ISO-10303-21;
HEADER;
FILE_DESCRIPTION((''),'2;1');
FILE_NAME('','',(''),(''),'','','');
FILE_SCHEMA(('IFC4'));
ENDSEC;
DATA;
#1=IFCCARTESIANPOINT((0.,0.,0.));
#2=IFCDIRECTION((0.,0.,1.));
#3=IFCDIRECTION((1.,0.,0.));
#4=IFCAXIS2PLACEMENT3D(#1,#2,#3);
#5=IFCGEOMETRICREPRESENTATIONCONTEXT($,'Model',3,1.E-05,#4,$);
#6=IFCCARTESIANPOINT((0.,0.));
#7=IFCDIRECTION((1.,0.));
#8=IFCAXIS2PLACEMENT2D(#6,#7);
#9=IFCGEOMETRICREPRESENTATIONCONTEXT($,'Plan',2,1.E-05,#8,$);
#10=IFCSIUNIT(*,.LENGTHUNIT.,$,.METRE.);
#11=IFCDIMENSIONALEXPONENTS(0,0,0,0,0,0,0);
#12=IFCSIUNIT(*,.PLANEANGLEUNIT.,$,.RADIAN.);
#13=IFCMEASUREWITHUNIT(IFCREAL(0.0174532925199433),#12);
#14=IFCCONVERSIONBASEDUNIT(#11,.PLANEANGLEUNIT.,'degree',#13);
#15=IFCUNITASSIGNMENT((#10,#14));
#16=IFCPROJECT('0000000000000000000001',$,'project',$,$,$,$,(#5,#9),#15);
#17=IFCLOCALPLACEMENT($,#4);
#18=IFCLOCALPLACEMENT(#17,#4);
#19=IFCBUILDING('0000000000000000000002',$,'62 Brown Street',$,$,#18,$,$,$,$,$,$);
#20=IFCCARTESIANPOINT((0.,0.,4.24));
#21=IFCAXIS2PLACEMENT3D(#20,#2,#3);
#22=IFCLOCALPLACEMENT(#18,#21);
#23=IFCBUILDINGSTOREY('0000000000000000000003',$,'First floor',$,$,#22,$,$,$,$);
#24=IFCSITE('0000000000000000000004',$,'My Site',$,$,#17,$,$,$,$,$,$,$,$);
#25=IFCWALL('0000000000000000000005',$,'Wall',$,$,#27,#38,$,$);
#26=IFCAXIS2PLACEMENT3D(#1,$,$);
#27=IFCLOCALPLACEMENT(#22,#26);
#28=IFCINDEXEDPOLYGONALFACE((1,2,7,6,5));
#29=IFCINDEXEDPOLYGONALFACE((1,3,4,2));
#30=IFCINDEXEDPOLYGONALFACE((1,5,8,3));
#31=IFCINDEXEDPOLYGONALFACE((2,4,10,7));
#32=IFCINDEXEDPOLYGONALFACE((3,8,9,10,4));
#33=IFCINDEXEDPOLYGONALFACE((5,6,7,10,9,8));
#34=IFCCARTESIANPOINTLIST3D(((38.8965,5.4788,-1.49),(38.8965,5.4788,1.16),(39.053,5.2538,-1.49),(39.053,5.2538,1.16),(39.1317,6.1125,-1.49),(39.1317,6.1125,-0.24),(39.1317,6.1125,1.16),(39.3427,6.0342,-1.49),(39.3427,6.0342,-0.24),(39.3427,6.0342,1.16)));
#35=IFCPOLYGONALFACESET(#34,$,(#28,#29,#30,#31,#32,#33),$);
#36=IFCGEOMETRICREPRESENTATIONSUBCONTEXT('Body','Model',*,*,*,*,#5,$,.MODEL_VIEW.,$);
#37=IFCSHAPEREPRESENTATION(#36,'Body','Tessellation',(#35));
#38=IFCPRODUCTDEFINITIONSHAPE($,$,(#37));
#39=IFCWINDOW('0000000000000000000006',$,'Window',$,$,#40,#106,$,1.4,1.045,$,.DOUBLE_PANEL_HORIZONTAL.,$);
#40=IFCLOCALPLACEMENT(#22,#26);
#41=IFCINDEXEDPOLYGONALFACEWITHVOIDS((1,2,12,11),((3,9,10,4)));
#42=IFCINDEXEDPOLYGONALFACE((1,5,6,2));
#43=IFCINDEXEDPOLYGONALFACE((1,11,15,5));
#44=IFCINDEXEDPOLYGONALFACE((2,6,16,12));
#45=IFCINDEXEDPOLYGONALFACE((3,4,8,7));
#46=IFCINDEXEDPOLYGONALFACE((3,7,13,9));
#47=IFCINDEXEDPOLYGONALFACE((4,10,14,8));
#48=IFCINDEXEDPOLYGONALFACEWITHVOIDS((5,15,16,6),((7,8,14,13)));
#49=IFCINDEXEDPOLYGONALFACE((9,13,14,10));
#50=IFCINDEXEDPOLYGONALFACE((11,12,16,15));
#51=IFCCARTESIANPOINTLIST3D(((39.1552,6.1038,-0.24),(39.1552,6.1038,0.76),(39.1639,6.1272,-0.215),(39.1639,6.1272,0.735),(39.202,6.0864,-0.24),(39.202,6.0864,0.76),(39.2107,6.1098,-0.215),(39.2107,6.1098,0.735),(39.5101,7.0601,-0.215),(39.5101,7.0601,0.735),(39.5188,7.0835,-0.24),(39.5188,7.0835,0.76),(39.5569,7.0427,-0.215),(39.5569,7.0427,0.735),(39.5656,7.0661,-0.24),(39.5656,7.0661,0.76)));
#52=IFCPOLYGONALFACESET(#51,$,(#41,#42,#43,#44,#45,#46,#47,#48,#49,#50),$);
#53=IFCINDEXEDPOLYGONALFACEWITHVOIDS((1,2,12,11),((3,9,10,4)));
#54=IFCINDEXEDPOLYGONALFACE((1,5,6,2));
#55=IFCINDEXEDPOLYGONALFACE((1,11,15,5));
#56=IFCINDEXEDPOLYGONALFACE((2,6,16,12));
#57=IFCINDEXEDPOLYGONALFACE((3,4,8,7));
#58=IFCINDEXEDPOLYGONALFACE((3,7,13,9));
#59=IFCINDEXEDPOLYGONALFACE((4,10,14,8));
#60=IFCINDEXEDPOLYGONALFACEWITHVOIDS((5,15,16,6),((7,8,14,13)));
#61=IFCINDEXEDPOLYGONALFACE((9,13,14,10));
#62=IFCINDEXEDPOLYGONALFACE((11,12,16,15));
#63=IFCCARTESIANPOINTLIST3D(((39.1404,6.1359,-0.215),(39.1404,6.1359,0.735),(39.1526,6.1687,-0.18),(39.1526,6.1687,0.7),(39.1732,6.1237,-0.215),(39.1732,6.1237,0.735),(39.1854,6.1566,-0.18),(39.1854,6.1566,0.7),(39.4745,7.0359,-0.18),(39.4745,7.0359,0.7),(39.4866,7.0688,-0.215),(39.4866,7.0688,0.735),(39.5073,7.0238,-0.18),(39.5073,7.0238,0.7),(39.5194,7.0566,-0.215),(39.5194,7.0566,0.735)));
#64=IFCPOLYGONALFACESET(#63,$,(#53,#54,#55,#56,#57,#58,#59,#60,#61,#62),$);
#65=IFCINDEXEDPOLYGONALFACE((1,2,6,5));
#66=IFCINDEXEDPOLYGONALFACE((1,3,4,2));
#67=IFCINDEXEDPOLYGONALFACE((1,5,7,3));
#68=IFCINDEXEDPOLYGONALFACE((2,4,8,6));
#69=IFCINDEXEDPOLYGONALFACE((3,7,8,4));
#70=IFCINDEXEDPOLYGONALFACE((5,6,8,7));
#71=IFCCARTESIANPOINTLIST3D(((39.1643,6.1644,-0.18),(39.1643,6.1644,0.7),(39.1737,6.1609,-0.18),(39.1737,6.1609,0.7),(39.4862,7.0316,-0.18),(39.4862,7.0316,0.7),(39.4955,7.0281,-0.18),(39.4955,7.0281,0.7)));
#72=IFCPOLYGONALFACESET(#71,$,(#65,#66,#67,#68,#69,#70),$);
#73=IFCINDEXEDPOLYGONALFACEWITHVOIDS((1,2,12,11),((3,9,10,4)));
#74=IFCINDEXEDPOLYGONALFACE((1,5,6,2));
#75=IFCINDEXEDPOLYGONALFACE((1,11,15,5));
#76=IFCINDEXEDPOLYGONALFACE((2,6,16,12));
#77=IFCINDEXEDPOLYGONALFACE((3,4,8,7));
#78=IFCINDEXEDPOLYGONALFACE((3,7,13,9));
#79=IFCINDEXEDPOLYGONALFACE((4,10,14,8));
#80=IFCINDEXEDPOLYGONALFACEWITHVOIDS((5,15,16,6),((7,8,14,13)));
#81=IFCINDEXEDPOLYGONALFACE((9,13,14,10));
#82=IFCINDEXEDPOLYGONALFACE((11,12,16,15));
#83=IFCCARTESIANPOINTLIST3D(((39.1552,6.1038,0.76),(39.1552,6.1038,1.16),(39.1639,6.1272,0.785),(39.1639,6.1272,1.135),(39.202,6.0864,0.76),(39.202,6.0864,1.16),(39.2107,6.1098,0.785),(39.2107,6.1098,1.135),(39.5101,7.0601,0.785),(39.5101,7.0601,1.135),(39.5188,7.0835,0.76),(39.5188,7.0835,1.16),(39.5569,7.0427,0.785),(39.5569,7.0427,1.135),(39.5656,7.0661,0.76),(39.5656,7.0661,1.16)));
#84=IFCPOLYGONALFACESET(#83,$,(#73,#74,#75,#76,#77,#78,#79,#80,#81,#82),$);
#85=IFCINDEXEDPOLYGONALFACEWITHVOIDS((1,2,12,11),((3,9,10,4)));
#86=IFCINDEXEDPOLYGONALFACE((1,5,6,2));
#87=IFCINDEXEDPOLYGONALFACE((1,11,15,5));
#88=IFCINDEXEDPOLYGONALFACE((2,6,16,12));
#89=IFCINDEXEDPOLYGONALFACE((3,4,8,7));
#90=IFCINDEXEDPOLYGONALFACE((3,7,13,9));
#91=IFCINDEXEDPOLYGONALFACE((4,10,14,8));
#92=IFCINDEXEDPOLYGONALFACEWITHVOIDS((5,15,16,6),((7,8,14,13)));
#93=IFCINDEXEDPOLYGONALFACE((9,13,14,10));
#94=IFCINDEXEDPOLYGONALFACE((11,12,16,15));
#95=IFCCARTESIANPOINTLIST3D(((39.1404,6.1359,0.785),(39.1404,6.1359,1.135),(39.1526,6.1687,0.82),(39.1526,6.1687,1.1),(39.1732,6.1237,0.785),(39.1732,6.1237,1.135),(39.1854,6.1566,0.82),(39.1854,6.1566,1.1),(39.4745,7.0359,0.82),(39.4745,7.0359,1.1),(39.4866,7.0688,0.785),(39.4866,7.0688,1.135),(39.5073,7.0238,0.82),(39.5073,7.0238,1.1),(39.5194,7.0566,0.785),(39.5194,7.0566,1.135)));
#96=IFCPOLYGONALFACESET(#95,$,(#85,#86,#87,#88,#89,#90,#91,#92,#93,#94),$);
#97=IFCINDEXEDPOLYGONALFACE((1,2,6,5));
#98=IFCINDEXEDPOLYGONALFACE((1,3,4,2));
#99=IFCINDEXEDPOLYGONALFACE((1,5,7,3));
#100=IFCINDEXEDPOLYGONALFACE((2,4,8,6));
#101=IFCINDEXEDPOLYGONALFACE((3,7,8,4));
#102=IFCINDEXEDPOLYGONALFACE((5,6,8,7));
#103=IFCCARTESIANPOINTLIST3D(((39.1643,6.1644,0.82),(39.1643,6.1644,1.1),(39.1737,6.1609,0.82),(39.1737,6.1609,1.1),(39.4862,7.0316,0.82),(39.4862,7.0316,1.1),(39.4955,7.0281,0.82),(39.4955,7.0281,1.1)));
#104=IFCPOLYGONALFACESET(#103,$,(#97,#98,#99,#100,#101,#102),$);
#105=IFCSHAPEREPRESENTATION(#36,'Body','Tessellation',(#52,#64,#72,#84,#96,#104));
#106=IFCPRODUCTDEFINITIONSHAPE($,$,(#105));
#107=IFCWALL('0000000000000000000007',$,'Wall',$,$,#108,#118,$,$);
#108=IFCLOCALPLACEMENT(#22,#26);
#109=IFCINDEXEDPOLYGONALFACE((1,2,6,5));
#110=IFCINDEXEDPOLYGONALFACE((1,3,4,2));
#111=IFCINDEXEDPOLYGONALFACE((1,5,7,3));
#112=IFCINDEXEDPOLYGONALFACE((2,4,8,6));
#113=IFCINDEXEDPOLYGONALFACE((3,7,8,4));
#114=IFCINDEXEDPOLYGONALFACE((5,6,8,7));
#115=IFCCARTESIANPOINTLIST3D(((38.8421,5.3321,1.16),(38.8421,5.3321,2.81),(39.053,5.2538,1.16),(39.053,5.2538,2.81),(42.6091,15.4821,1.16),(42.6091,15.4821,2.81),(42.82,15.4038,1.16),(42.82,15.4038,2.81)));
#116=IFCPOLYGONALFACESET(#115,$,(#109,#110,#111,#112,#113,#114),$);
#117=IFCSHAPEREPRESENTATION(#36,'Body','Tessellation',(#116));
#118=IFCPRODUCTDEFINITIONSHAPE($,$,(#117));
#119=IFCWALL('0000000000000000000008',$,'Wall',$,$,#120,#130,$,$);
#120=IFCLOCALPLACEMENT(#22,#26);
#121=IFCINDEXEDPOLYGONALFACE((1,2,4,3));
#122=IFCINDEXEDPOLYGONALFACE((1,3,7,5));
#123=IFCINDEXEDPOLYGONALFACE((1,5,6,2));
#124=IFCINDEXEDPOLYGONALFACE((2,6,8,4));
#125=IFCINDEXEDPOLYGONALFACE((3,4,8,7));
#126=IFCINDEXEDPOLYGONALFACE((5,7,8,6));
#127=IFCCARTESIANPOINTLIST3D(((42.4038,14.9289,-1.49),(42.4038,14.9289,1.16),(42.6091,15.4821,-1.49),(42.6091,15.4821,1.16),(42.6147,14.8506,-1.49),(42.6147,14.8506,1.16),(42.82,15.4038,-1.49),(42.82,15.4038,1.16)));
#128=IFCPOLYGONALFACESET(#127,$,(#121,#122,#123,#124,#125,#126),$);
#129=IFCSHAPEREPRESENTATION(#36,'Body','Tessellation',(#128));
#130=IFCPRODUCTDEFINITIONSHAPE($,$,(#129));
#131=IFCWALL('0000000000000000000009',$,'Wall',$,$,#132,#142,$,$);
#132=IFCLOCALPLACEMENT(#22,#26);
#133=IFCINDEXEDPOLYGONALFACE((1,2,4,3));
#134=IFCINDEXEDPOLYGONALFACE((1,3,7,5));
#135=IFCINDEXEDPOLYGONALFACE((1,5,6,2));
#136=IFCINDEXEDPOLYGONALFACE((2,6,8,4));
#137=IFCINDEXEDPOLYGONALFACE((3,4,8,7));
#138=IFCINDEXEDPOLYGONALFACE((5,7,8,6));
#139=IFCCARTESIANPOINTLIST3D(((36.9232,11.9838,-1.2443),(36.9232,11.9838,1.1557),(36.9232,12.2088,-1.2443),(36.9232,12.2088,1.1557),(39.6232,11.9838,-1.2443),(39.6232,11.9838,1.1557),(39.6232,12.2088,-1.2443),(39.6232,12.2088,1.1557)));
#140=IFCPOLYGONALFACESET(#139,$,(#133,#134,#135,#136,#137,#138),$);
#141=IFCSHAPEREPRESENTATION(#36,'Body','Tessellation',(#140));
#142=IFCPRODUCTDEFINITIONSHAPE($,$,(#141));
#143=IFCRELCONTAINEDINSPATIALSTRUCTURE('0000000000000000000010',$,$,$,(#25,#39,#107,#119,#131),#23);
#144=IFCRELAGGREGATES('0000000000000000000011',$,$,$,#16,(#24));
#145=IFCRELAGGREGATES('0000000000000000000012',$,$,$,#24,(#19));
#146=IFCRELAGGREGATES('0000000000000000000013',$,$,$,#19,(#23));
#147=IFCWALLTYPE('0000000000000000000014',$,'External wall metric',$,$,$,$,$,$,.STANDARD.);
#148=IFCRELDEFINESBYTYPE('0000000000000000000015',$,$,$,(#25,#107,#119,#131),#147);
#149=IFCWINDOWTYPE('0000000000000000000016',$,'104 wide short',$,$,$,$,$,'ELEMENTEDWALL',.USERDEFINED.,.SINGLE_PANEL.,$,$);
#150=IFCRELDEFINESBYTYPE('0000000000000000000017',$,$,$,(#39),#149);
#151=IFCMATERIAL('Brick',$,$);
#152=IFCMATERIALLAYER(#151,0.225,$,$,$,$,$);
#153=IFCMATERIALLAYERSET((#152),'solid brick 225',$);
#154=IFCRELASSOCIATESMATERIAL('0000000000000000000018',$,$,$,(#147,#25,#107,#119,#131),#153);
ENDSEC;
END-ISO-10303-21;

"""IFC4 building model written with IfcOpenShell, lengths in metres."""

from ifc_helpers import new_model, entity, si_unit, converted_unit, frame, origin_with_axes, origin_2d_with_axis, place, context, subcontext, project, spatial, line, indexed_curve, outline, extrude, clip, halfspace, shape, source, transform, mapped, material, layer, layer_set, layer_usage, type_object, type_shapes, element, fill, save


model = new_model("IFC4")

# Units and contexts
model_context = context("Model", 3, precision=1e-05, world=origin_with_axes())
plan_context = context("Plan", 2, precision=1e-05, world=origin_2d_with_axis())
body_context_1 = subcontext(model_context, "Body", "Model", "MODEL_VIEW")
body_context_2 = subcontext(plan_context, "Body", "Plan", "PLAN_VIEW")
ifc_project = project(units=[si_unit("LENGTHUNIT", "METRE"), converted_unit("PLANEANGLEUNIT", "degree", entity("IfcReal", 0.0174532925199433), si_unit("PLANEANGLEUNIT", "RADIAN"), dimensions=[0, 0, 0, 0, 0, 0, 0])], contexts=[model_context, plan_context])

# Site, building, storey
site_placement = place(None, origin_with_axes())
site = spatial("IfcSite", under=ifc_project, at=site_placement, Name="My Site")
building_placement = place(site_placement, origin_with_axes())
building = spatial("IfcBuilding", under=site, at=building_placement, Name="62 Brown Street")
storey_placement = place(building_placement, frame((0.0, 0.0, 4.24), z_axis=(0.0, 0.0, 1.0), x_axis=(1.0, 0.0, 0.0)))
storey = spatial("IfcBuildingStorey", under=building, at=storey_placement, Name="First floor")

# Shared definitions
ifc_material_1 = material(Name="Brick")
ifc_layer_1 = layer(ifc_material_1, 0.225)
ifc_layer_set_1 = layer_set([ifc_layer_1], Name="solid brick 225")
wall_type_1 = type_object("IfcWallType", Name="External wall metric", PredefinedType="STANDARD", material=ifc_layer_set_1)

# Wall, opening, window
ifc_layer_usage_1 = layer_usage(ifc_layer_set_1, "AXIS2", "POSITIVE", 0.0)
wall_1_placement = place(storey_placement, frame((39.024, 5.1755, -1.49), z_axis=(0.0, 0.0, 1.0), x_axis=(0.347944, 0.937515, 0.0)))
wall_1 = element("IfcWall", 1, at=wall_1_placement, inside=storey, type_object=wall_type_1, material=ifc_layer_usage_1, Name="Wall", context=body_context_1, shape_type="Clipping", body=[
    clip(extrude(outline(indexed_curve([(0.0, 0.0), (0.0, 0.225), (0.9159, 0.225), (0.9159, 0.0), (0.0, 0.0)], self_intersect=False)), origin_with_axes(), (0.0, 0.0, 1.0), 2.65), halfspace(frame((0.0835, 0.0, -2.75), z_axis=(-0.596249, 0.414702, 0.0), x_axis=(0.156491, 0.225, 0.0)), False)),
])
shared_shape_1 = source(origin_with_axes(), body_context_1, "Body", "SweptSolid", [
    extrude(outline(indexed_curve([(0.0, 0.0), (1.045, 0.0), (1.045, 1.4), (0.0, 1.4)], segments=[line(1, 2, 3, 4, 1)])), frame((0.0, -0.1, 0.0), z_axis=(0.0, -1.0, 0.0), x_axis=(1.0, 0.0, 0.0)), (0.0, 0.0, -1.0), 0.425),
])
opening_placement = place(wall_1_placement, frame((0.9159, 0.0, 1.25), z_axis=(0.0, 0.0, 1.0), x_axis=(1.0, 0.0, 0.0)))
opening = element("IfcOpeningElement", 2, at=opening_placement, cuts=wall_1, PredefinedType="OPENING", context=body_context_1, shape_type="MappedRepresentation", body=[
    mapped(shared_shape_1, transform((0.0, 0.0, 0.0), x_axis=(1.0, 0.0, 0.0), y_axis=(0.0, 1.0, 0.0), z_axis=(0.0, 0.0, 1.0), scale=1.0)),
])
window_type = type_object("IfcWindowType", Name="104 wide short", ElementType="ELEMENTEDWALL", PartitioningType="SINGLE_PANEL", PredefinedType="USERDEFINED")
shared_shape_2 = source(origin_with_axes(), body_context_1, "Body", "SweptSolid", [
    extrude(outline(indexed_curve([(0.0, 0.0), (1.045, 0.0), (1.045, 1.0), (0.0, 1.0)], segments=[line(1, 2, 3, 4, 1)]), holes=[indexed_curve([(0.025, 0.025), (1.02, 0.025), (1.02, 0.975), (0.025, 0.975)], segments=[line(1, 2, 3, 4, 1)])]), frame((0.0, 0.15, 0.0), z_axis=(0.0, -1.0, 0.0), x_axis=(1.0, 0.0, 0.0)), (0.0, 0.0, -1.0), 0.05),
    extrude(outline(indexed_curve([(0.0, 0.0), (0.995, 0.0), (0.995, 0.95), (0.0, 0.95)], segments=[line(1, 2, 3, 4, 1)]), holes=[indexed_curve([(0.035, 0.035), (0.96, 0.035), (0.96, 0.915), (0.035, 0.915)], segments=[line(1, 2, 3, 4, 1)])]), frame((0.025, 0.19, 0.025), z_axis=(0.0, -1.0, 0.0), x_axis=(1.0, 0.0, 0.0)), (0.0, 0.0, -1.0), 0.035),
    extrude(outline(indexed_curve([(0.035, 0.035), (0.96, 0.035), (0.96, 0.915), (0.035, 0.915)], segments=[line(1, 2, 3, 4, 1)])), frame((0.025, 0.2025, 0.025), z_axis=(0.0, -1.0, 0.0), x_axis=(1.0, 0.0, 0.0)), (0.0, 0.0, -1.0), 0.01),
    extrude(outline(indexed_curve([(0.0, 0.0), (1.045, 0.0), (1.045, 0.4), (0.0, 0.4)], segments=[line(1, 2, 3, 4, 1)]), holes=[indexed_curve([(0.025, 0.025), (1.02, 0.025), (1.02, 0.375), (0.025, 0.375)], segments=[line(1, 2, 3, 4, 1)])]), frame((0.0, 0.15, 1.0), z_axis=(0.0, -1.0, 0.0), x_axis=(1.0, 0.0, 0.0)), (0.0, 0.0, -1.0), 0.05),
    extrude(outline(indexed_curve([(0.0, 0.0), (0.995, 0.0), (0.995, 0.35), (0.0, 0.35)], segments=[line(1, 2, 3, 4, 1)]), holes=[indexed_curve([(0.035, 0.035), (0.96, 0.035), (0.96, 0.315), (0.035, 0.315)], segments=[line(1, 2, 3, 4, 1)])]), frame((0.025, 0.19, 1.025), z_axis=(0.0, -1.0, 0.0), x_axis=(1.0, 0.0, 0.0)), (0.0, 0.0, -1.0), 0.035),
    extrude(outline(indexed_curve([(0.035, 0.035), (0.96, 0.035), (0.96, 0.315), (0.035, 0.315)], segments=[line(1, 2, 3, 4, 1)])), frame((0.025, 0.2025, 1.025), z_axis=(0.0, -1.0, 0.0), x_axis=(1.0, 0.0, 0.0)), (0.0, 0.0, -1.0), 0.01),
])
shared_shape_3 = source(origin_with_axes(), body_context_2, "Body", "Curve2D", [
    entity("IfcIndexedPolyCurve", entity("IfcCartesianPointList2D", [[0.025, 0.15], [1.02, 0.15]])),
    entity("IfcIndexedPolyCurve", entity("IfcCartesianPointList2D", [[0.0, 0.2], [0.025, 0.2], [0.025, 0.15], [0.0, 0.15]]), [entity("IfcLineIndex", [1, 2, 3, 4, 1])]),
    entity("IfcIndexedPolyCurve", entity("IfcCartesianPointList2D", [[1.045, 0.2], [1.02, 0.2], [1.02, 0.15], [1.045, 0.15]]), [entity("IfcLineIndex", [1, 2, 3, 4, 1])]),
    entity("IfcIndexedPolyCurve", entity("IfcCartesianPointList2D", [[0.025, 0.19], [0.06, 0.19], [0.06, 0.225], [0.025, 0.225]]), [entity("IfcLineIndex", [1, 2, 3, 4, 1])]),
    entity("IfcIndexedPolyCurve", entity("IfcCartesianPointList2D", [[1.02, 0.19], [0.985, 0.19], [0.985, 0.225], [1.02, 0.225]]), [entity("IfcLineIndex", [1, 2, 3, 4, 1])]),
    entity("IfcIndexedPolyCurve", entity("IfcCartesianPointList2D", [[0.06, 0.19], [0.985, 0.19]])),
    entity("IfcIndexedPolyCurve", entity("IfcCartesianPointList2D", [[0.06, 0.225], [0.985, 0.225]])),
    entity("IfcIndexedPolyCurve", entity("IfcCartesianPointList2D", [[0.06, 0.2075], [0.985, 0.2075]])),
])
type_shapes(window_type, [shared_shape_2, shared_shape_3])
window_1_placement = place(opening_placement, frame((0.0, 0.0, 0.0), z_axis=(0.0, 0.0, 1.0), x_axis=(1.0, 0.0, 0.0)))
window_1 = element("IfcWindow", 3, at=window_1_placement, inside=storey, type_object=window_type, Name="Window", OverallHeight=1.4, OverallWidth=1.045, PartitioningType="DOUBLE_PANEL_HORIZONTAL", shapes=[
    shape(body_context_1, "Body", "MappedRepresentation", [mapped(shared_shape_2, transform((0.0, 0.0, 0.0), x_axis=(1.0, 0.0, 0.0), y_axis=(0.0, 1.0, 0.0), z_axis=(0.0, 0.0, 1.0), scale=1.0))]),
    shape(body_context_2, "Body", "MappedRepresentation", [mapped(shared_shape_3, transform((0.0, 0.0, 0.0), x_axis=(1.0, 0.0, 0.0), y_axis=(0.0, 1.0, 0.0), z_axis=(0.0, 0.0, 1.0), scale=1.0))]),
])
fill(opening, window_1)

# Walls
ifc_layer_usage_2 = layer_usage(ifc_layer_set_1, "AXIS2", "POSITIVE", 0.0)
wall_2_placement = place(storey_placement, frame((39.053, 5.2538, 1.16), z_axis=(0.0, 0.0, 1.0), x_axis=(0.347944, 0.937515, 0.0)))
element("IfcWall", 4, at=wall_2_placement, inside=storey, type_object=wall_type_1, material=ifc_layer_usage_2, Name="Wall", context=body_context_1, shape_type="SweptSolid", body=[
    extrude(outline(indexed_curve([(0.0, 0.0), (0.0, 0.225), (10.8265, 0.225), (10.8265, 0.0), (0.0, 0.0)], self_intersect=False)), origin_with_axes(), (0.0, 0.0, 1.0), 1.65),
])
ifc_layer_usage_3 = layer_usage(ifc_layer_set_1, "AXIS2", "POSITIVE", 0.0)
wall_3_placement = place(storey_placement, frame((42.6147, 14.8506, -1.49), z_axis=(0.0, 0.0, 1.0), x_axis=(0.347944, 0.937515, 0.0)))
element("IfcWall", 5, at=wall_3_placement, inside=storey, type_object=wall_type_1, material=ifc_layer_usage_3, Name="Wall", context=body_context_1, shape_type="SweptSolid", body=[
    extrude(outline(indexed_curve([(0.0, 0.0), (0.0, 0.225), (0.5901, 0.225), (0.5901, 0.0), (0.0, 0.0)], self_intersect=False)), origin_with_axes(), (0.0, 0.0, 1.0), 2.65),
])
ifc_layer_usage_4 = layer_usage(ifc_layer_set_1, "AXIS2", "POSITIVE", 0.0)
wall_4_placement = place(storey_placement, frame((36.9232, 11.9838, -1.2443), z_axis=(0.0, 0.0, 1.0), x_axis=(1.0, 0.0, 0.0)))
element("IfcWall", 6, at=wall_4_placement, inside=storey, type_object=wall_type_1, material=ifc_layer_usage_4, Name="Wall", context=body_context_1, shape_type="SweptSolid", body=[
    extrude(outline(indexed_curve([(0.0, 0.0), (0.0, 0.225), (2.7, 0.225), (2.7, 0.0), (0.0, 0.0)], self_intersect=False)), origin_with_axes(), (0.0, 0.0, 1.0), 2.4),
])

save(model, "model.ifc")
